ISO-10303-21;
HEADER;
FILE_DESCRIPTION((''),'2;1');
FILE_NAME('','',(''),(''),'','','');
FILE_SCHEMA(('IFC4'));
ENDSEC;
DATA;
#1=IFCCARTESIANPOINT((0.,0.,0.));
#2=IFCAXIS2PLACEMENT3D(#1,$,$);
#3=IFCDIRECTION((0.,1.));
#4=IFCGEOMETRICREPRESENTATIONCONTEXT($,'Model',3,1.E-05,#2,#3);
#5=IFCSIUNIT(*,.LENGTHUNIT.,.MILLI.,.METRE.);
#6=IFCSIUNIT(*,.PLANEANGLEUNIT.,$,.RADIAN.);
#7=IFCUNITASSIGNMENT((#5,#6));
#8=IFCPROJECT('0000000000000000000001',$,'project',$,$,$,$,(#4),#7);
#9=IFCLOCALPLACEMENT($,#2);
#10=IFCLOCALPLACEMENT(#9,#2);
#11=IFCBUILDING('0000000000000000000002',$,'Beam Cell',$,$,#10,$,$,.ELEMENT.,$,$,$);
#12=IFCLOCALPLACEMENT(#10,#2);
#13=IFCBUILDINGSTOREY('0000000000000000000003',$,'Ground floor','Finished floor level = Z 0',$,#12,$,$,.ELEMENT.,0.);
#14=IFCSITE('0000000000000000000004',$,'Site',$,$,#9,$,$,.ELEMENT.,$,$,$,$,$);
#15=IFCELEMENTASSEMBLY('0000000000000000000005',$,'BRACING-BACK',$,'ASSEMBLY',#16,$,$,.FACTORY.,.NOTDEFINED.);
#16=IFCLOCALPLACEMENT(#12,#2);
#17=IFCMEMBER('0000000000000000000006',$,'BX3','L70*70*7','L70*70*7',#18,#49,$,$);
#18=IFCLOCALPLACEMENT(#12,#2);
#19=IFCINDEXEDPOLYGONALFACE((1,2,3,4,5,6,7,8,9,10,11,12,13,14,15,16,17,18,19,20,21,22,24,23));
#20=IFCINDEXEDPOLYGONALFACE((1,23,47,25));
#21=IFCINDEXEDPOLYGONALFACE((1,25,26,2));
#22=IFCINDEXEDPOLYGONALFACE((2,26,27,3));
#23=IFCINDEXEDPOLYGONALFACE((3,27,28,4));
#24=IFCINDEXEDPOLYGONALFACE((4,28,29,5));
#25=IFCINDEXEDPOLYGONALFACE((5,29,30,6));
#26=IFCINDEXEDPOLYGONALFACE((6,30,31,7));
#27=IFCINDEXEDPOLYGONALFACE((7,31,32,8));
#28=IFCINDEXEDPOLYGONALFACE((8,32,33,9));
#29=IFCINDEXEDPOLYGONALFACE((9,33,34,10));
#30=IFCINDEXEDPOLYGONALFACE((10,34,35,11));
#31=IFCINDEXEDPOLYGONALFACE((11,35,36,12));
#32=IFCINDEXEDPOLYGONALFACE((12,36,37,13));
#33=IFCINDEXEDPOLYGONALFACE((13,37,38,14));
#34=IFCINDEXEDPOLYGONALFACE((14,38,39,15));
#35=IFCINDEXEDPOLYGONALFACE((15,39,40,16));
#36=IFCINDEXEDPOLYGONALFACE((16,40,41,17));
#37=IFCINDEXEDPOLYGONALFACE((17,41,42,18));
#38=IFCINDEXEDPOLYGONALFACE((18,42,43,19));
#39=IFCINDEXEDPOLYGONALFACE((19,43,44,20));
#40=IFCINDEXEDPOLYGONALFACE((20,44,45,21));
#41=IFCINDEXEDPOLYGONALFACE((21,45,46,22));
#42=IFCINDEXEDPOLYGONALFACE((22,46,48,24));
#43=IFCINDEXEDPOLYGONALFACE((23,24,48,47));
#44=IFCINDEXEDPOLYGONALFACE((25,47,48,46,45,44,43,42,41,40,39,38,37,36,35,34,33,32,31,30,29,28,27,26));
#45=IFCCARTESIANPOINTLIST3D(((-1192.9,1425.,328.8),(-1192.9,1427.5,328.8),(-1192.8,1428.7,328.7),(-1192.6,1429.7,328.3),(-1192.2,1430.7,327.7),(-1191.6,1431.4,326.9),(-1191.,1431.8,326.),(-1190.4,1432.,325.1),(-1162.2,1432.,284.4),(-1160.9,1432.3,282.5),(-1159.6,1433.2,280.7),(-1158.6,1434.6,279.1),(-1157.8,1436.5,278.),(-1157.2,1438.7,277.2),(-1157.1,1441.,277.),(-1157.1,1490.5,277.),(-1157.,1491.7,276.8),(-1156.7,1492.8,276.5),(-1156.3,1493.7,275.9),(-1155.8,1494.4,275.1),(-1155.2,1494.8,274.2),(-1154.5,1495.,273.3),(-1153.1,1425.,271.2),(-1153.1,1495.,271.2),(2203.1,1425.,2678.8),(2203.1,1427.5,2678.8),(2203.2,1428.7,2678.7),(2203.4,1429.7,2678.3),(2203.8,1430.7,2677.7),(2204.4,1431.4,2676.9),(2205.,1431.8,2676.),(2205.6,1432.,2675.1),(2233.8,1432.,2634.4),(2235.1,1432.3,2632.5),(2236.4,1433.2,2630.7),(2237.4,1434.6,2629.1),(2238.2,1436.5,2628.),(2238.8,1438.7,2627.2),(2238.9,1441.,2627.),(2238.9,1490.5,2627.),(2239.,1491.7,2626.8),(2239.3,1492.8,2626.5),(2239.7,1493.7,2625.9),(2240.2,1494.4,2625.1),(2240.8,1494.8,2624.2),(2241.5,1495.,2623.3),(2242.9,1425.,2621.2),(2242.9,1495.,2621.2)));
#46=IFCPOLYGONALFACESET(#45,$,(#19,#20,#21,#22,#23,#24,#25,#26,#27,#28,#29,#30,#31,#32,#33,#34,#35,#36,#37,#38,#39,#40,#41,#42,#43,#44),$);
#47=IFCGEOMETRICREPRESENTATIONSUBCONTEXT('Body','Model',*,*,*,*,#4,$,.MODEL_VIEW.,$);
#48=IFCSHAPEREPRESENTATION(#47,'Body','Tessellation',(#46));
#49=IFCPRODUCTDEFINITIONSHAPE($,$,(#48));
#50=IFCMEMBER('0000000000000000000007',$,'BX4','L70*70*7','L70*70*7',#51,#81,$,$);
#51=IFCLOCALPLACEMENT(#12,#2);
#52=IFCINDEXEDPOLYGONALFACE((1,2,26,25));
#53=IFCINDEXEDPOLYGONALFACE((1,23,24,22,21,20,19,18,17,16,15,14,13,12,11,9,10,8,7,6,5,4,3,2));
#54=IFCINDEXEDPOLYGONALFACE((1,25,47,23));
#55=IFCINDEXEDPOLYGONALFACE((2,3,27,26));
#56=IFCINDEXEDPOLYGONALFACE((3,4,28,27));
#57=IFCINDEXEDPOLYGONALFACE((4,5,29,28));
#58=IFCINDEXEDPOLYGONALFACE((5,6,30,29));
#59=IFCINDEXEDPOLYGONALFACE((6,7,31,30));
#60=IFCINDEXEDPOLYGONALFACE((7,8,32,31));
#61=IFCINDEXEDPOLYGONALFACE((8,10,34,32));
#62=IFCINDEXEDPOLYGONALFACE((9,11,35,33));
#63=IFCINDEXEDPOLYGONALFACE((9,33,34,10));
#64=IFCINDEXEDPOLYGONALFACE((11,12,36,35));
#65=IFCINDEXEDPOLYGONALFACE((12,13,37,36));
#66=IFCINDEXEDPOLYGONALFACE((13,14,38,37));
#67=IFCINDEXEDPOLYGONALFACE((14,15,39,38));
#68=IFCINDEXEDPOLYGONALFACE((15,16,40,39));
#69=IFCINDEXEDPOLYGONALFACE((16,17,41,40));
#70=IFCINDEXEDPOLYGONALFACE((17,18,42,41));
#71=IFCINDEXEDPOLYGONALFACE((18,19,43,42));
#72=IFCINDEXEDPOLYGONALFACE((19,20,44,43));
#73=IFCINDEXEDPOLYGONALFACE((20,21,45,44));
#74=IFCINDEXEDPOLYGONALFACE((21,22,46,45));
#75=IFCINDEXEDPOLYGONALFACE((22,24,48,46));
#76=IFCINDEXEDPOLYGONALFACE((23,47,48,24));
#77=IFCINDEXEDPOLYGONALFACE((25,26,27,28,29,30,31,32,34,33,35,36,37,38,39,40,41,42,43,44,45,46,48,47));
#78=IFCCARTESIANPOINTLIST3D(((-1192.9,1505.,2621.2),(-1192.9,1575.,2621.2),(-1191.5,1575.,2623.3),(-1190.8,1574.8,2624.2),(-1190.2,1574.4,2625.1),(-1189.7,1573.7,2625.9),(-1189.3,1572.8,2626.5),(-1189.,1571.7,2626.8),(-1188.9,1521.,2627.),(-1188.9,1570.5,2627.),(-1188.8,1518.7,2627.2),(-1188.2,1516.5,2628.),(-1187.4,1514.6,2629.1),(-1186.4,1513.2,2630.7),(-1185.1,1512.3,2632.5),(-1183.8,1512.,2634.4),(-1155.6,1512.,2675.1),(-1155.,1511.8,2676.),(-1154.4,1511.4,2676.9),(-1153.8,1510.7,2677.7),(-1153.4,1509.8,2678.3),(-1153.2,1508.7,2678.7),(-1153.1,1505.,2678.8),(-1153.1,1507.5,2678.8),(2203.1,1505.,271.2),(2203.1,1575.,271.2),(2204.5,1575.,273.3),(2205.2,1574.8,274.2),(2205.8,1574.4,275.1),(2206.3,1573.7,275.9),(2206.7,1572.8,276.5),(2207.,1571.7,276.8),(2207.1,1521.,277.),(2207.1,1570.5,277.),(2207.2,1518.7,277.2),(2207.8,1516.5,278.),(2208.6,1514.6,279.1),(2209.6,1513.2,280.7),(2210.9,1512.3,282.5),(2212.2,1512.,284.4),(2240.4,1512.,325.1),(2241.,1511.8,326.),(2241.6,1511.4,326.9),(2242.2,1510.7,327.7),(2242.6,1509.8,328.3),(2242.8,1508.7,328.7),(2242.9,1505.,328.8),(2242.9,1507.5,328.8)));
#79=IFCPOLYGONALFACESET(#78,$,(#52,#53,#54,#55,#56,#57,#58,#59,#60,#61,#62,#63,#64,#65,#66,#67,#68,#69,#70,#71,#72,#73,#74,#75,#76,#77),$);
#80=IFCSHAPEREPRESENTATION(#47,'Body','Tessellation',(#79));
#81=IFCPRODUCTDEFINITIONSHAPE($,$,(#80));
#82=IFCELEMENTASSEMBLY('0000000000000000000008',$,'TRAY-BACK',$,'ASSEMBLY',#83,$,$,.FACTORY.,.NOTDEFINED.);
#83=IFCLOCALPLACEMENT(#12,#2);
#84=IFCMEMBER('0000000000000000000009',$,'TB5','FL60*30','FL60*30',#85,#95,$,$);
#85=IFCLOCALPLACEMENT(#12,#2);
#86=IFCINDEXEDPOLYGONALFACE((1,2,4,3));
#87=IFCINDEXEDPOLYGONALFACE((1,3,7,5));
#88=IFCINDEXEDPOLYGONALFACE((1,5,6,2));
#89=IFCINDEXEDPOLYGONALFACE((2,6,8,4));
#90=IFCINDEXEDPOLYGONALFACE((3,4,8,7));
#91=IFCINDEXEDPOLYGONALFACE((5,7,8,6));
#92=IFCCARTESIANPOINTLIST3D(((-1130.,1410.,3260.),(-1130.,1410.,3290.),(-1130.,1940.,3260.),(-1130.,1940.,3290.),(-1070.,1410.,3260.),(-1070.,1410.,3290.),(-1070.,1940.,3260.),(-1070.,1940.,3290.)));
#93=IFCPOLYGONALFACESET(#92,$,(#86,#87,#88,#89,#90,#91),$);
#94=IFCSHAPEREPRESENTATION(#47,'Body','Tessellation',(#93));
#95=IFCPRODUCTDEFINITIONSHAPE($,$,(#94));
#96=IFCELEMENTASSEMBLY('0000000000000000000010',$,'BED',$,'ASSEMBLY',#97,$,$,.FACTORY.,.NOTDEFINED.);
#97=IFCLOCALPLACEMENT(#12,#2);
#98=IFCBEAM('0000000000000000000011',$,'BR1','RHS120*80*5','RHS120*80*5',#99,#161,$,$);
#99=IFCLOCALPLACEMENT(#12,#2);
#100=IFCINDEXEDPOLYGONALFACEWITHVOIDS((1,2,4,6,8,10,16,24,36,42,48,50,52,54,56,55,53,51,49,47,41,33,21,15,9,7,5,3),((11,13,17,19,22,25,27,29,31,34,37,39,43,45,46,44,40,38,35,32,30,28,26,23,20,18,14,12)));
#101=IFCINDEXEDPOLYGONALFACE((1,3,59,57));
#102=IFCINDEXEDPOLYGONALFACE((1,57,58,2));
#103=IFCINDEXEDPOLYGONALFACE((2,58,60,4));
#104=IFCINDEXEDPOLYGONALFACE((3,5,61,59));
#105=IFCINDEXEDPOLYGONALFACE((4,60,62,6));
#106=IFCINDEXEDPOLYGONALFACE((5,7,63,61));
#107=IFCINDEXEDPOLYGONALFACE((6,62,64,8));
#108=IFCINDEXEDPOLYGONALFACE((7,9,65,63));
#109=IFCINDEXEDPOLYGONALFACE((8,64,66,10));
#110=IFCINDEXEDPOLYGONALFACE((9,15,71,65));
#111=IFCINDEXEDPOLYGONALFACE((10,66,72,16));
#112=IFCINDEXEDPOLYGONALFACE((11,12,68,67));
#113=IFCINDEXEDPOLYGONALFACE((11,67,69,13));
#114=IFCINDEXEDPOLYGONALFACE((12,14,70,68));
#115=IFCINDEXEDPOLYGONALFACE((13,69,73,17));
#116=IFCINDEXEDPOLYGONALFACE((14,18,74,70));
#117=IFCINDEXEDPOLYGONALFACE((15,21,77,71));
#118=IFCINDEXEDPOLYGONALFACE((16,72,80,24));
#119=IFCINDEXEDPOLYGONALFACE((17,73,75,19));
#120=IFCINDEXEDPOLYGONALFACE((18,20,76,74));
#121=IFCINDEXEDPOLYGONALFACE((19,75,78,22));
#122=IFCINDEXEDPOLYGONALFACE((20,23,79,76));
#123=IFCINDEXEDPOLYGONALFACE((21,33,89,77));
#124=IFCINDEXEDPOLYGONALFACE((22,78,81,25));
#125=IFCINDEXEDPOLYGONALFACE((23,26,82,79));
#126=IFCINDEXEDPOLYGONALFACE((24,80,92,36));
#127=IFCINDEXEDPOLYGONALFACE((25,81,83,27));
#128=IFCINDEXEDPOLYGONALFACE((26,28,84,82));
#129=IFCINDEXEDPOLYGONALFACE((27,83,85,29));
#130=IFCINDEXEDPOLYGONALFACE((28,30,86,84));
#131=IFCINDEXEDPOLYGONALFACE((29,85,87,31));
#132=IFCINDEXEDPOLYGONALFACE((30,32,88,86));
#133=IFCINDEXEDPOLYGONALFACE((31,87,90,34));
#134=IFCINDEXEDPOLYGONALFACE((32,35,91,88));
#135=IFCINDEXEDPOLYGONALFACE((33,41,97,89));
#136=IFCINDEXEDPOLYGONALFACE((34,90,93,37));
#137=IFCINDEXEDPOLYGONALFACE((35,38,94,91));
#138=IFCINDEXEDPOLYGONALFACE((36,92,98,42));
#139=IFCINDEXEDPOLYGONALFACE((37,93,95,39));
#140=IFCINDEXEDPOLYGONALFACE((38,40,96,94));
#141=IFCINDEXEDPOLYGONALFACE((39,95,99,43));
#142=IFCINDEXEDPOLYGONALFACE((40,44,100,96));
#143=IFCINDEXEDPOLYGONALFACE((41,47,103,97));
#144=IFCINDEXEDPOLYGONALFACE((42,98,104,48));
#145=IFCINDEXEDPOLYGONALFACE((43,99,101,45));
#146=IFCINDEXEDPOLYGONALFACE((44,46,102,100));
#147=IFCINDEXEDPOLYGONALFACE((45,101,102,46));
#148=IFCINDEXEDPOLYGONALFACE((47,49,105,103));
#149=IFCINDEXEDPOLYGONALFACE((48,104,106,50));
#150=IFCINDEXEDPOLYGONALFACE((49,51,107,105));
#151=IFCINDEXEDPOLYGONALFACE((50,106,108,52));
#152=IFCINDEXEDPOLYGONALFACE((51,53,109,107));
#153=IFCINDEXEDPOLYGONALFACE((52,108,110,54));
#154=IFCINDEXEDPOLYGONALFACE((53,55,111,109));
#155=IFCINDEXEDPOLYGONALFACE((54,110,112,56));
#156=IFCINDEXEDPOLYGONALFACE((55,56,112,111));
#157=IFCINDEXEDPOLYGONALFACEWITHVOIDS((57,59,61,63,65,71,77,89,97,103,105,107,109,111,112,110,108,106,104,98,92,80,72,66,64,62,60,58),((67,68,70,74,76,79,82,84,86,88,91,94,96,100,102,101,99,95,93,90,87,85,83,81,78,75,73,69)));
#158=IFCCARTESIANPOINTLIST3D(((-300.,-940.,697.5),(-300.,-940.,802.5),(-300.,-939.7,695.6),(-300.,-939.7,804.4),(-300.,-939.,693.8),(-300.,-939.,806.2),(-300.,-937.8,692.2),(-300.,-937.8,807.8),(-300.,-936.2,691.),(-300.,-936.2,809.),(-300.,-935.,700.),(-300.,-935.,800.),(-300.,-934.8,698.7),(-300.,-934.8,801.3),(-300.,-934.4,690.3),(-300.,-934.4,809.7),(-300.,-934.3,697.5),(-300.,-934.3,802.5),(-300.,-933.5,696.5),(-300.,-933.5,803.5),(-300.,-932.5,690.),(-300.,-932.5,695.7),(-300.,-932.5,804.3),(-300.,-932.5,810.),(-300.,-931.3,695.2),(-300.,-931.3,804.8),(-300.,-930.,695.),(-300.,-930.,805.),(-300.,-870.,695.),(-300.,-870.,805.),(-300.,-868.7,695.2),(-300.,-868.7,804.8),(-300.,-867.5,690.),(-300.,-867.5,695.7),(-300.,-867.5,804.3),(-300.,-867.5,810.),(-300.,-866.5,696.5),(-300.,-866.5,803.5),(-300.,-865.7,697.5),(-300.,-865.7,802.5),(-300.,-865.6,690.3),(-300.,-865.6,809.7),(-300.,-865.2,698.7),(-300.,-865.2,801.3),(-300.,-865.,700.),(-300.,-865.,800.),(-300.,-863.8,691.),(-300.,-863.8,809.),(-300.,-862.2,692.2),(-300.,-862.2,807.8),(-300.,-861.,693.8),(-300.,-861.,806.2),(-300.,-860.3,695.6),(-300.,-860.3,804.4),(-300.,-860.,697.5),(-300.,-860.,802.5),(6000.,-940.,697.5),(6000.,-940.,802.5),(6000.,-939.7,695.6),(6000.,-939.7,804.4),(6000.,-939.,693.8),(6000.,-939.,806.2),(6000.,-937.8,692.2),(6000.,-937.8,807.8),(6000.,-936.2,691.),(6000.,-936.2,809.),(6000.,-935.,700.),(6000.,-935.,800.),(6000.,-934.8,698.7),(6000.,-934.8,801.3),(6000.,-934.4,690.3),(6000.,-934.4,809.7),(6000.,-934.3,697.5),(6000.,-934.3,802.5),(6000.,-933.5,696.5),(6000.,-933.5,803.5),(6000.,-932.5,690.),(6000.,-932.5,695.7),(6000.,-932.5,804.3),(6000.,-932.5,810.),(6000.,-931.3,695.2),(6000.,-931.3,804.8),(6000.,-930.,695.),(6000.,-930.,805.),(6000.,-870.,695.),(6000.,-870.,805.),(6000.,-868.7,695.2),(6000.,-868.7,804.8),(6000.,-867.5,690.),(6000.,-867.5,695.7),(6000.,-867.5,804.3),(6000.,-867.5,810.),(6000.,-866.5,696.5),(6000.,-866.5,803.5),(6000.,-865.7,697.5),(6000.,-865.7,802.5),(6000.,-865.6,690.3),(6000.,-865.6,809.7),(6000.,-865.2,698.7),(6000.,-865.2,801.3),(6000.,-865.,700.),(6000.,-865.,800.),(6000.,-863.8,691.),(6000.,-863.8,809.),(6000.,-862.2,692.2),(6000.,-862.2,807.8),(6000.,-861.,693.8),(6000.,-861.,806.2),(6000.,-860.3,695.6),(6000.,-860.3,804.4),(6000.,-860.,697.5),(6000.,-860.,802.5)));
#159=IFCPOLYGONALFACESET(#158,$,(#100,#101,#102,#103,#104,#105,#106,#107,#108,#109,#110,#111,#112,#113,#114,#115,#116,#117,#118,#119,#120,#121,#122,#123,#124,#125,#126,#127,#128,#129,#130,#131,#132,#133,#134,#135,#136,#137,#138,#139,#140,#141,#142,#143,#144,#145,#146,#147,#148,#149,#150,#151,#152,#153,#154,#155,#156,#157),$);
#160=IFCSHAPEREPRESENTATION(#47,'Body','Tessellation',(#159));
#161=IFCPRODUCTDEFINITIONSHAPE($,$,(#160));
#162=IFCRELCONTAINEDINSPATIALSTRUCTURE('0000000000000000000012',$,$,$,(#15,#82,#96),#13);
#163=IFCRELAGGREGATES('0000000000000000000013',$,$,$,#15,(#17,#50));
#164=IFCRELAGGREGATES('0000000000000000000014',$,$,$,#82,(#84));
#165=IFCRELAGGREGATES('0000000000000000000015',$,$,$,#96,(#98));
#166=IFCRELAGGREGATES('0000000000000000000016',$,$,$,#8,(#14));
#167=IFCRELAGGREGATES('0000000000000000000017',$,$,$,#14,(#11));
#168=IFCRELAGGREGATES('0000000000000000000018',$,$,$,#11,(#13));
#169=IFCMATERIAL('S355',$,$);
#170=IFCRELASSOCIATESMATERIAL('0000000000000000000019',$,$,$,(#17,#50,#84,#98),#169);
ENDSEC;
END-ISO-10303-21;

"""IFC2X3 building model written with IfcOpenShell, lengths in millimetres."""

from ifc_helpers import new_model, si_unit, direction, frame, origin, origin_2d, place, context, subcontext, project, spatial, rectangle, hollow_rectangle, l_section, extrude, material, element, aggregate, save


model = new_model("IFC2X3")

# Units and contexts
model_context = context("Model", 3, precision=1e-05, world=origin(), true_north=direction((0.0, 1.0)))
body_context = subcontext(model_context, "Body", "Model", "MODEL_VIEW")
ifc_project = project(units=[si_unit("LENGTHUNIT", "METRE", prefix="MILLI"), si_unit("PLANEANGLEUNIT", "RADIAN")], contexts=[model_context])

# Site, building, storey
site_placement = place(None, origin())
site = spatial("IfcSite", under=ifc_project, at=site_placement, Name="Site", CompositionType="ELEMENT")
building_placement = place(site_placement, origin())
building = spatial("IfcBuilding", under=site, at=building_placement, Name="Beam Cell", CompositionType="ELEMENT")
storey_placement = place(building_placement, origin())
storey = spatial("IfcBuildingStorey", under=building, at=storey_placement, Name="Ground floor", Description="Finished floor level = Z 0", CompositionType="ELEMENT", Elevation=0.0)

# Shared definitions
ifc_material = material(Name="S355")

# Element assembly, members
assembly_1_placement = place(storey_placement, origin())
assembly_1 = element("IfcElementAssembly", 1, at=assembly_1_placement, inside=storey, Name="BRACING-BACK", ObjectType="ASSEMBLY", AssemblyPlace="FACTORY", PredefinedType="NOTDEFINED")
member_1_placement = place(storey_placement, frame((-1173.0, 1460.0, 300.0), z_axis=(0.822314, 0.0, 0.569034), x_axis=(0.0, 1.0, 0.0)))
member_1 = element("IfcMember", 2, at=member_1_placement, material=ifc_material, Name="BX3", Description="L70*70*7", ObjectType="L70*70*7", context=body_context, shape_type="SweptSolid", body=[
    extrude(l_section(Depth=70.0, Width=70.0, Thickness=7.0, FilletRadius=9.0, EdgeRadius=4.5, at=origin_2d()), origin(), (0.0, 0.0, 1.0), 4129.8),
])
member_2_placement = place(storey_placement, frame((-1173.0, 1540.0, 2650.0), z_axis=(0.822314, 0.0, -0.569034), x_axis=(0.0, 1.0, 0.0)))
member_2 = element("IfcMember", 3, at=member_2_placement, material=ifc_material, Name="BX4", Description="L70*70*7", ObjectType="L70*70*7", context=body_context, shape_type="SweptSolid", body=[
    extrude(l_section(Depth=70.0, Width=70.0, Thickness=7.0, FilletRadius=9.0, EdgeRadius=4.5, at=origin_2d()), origin(), (0.0, 0.0, 1.0), 4129.8),
])
aggregate(assembly_1, [member_1, member_2])

# Element assembly, member
assembly_2_placement = place(storey_placement, origin())
assembly_2 = element("IfcElementAssembly", 4, at=assembly_2_placement, inside=storey, Name="TRAY-BACK", ObjectType="ASSEMBLY", AssemblyPlace="FACTORY", PredefinedType="NOTDEFINED")
member_3_placement = place(storey_placement, frame((-1100.0, 1410.0, 3275.0), z_axis=(0.0, 1.0, 0.0), x_axis=(1.0, 0.0, 0.0)))
member_3 = element("IfcMember", 5, at=member_3_placement, material=ifc_material, Name="TB5", Description="FL60*30", ObjectType="FL60*30", context=body_context, shape_type="SweptSolid", body=[
    extrude(rectangle(XDim=60.0, YDim=30.0, at=origin_2d()), origin(), (0.0, 0.0, 1.0), 530.0),
])
aggregate(assembly_2, [member_3])

# Element assembly, beam
assembly_3_placement = place(storey_placement, origin())
assembly_3 = element("IfcElementAssembly", 6, at=assembly_3_placement, inside=storey, Name="BED", ObjectType="ASSEMBLY", AssemblyPlace="FACTORY", PredefinedType="NOTDEFINED")
beam_1_placement = place(storey_placement, frame((-300.0, -900.0, 750.0), z_axis=(1.0, 0.0, 0.0), x_axis=(0.0, 1.0, 0.0)))
beam_1 = element("IfcBeam", 7, at=beam_1_placement, material=ifc_material, Name="BR1", Description="RHS120*80*5", ObjectType="RHS120*80*5", context=body_context, shape_type="SweptSolid", body=[
    extrude(hollow_rectangle(XDim=80.0, YDim=120.0, WallThickness=5.0, InnerFilletRadius=5.0, OuterFilletRadius=7.5, at=origin_2d()), origin(), (0.0, 0.0, 1.0), 6300.0),
])
aggregate(assembly_3, [beam_1])

save(model, "model.ifc")
